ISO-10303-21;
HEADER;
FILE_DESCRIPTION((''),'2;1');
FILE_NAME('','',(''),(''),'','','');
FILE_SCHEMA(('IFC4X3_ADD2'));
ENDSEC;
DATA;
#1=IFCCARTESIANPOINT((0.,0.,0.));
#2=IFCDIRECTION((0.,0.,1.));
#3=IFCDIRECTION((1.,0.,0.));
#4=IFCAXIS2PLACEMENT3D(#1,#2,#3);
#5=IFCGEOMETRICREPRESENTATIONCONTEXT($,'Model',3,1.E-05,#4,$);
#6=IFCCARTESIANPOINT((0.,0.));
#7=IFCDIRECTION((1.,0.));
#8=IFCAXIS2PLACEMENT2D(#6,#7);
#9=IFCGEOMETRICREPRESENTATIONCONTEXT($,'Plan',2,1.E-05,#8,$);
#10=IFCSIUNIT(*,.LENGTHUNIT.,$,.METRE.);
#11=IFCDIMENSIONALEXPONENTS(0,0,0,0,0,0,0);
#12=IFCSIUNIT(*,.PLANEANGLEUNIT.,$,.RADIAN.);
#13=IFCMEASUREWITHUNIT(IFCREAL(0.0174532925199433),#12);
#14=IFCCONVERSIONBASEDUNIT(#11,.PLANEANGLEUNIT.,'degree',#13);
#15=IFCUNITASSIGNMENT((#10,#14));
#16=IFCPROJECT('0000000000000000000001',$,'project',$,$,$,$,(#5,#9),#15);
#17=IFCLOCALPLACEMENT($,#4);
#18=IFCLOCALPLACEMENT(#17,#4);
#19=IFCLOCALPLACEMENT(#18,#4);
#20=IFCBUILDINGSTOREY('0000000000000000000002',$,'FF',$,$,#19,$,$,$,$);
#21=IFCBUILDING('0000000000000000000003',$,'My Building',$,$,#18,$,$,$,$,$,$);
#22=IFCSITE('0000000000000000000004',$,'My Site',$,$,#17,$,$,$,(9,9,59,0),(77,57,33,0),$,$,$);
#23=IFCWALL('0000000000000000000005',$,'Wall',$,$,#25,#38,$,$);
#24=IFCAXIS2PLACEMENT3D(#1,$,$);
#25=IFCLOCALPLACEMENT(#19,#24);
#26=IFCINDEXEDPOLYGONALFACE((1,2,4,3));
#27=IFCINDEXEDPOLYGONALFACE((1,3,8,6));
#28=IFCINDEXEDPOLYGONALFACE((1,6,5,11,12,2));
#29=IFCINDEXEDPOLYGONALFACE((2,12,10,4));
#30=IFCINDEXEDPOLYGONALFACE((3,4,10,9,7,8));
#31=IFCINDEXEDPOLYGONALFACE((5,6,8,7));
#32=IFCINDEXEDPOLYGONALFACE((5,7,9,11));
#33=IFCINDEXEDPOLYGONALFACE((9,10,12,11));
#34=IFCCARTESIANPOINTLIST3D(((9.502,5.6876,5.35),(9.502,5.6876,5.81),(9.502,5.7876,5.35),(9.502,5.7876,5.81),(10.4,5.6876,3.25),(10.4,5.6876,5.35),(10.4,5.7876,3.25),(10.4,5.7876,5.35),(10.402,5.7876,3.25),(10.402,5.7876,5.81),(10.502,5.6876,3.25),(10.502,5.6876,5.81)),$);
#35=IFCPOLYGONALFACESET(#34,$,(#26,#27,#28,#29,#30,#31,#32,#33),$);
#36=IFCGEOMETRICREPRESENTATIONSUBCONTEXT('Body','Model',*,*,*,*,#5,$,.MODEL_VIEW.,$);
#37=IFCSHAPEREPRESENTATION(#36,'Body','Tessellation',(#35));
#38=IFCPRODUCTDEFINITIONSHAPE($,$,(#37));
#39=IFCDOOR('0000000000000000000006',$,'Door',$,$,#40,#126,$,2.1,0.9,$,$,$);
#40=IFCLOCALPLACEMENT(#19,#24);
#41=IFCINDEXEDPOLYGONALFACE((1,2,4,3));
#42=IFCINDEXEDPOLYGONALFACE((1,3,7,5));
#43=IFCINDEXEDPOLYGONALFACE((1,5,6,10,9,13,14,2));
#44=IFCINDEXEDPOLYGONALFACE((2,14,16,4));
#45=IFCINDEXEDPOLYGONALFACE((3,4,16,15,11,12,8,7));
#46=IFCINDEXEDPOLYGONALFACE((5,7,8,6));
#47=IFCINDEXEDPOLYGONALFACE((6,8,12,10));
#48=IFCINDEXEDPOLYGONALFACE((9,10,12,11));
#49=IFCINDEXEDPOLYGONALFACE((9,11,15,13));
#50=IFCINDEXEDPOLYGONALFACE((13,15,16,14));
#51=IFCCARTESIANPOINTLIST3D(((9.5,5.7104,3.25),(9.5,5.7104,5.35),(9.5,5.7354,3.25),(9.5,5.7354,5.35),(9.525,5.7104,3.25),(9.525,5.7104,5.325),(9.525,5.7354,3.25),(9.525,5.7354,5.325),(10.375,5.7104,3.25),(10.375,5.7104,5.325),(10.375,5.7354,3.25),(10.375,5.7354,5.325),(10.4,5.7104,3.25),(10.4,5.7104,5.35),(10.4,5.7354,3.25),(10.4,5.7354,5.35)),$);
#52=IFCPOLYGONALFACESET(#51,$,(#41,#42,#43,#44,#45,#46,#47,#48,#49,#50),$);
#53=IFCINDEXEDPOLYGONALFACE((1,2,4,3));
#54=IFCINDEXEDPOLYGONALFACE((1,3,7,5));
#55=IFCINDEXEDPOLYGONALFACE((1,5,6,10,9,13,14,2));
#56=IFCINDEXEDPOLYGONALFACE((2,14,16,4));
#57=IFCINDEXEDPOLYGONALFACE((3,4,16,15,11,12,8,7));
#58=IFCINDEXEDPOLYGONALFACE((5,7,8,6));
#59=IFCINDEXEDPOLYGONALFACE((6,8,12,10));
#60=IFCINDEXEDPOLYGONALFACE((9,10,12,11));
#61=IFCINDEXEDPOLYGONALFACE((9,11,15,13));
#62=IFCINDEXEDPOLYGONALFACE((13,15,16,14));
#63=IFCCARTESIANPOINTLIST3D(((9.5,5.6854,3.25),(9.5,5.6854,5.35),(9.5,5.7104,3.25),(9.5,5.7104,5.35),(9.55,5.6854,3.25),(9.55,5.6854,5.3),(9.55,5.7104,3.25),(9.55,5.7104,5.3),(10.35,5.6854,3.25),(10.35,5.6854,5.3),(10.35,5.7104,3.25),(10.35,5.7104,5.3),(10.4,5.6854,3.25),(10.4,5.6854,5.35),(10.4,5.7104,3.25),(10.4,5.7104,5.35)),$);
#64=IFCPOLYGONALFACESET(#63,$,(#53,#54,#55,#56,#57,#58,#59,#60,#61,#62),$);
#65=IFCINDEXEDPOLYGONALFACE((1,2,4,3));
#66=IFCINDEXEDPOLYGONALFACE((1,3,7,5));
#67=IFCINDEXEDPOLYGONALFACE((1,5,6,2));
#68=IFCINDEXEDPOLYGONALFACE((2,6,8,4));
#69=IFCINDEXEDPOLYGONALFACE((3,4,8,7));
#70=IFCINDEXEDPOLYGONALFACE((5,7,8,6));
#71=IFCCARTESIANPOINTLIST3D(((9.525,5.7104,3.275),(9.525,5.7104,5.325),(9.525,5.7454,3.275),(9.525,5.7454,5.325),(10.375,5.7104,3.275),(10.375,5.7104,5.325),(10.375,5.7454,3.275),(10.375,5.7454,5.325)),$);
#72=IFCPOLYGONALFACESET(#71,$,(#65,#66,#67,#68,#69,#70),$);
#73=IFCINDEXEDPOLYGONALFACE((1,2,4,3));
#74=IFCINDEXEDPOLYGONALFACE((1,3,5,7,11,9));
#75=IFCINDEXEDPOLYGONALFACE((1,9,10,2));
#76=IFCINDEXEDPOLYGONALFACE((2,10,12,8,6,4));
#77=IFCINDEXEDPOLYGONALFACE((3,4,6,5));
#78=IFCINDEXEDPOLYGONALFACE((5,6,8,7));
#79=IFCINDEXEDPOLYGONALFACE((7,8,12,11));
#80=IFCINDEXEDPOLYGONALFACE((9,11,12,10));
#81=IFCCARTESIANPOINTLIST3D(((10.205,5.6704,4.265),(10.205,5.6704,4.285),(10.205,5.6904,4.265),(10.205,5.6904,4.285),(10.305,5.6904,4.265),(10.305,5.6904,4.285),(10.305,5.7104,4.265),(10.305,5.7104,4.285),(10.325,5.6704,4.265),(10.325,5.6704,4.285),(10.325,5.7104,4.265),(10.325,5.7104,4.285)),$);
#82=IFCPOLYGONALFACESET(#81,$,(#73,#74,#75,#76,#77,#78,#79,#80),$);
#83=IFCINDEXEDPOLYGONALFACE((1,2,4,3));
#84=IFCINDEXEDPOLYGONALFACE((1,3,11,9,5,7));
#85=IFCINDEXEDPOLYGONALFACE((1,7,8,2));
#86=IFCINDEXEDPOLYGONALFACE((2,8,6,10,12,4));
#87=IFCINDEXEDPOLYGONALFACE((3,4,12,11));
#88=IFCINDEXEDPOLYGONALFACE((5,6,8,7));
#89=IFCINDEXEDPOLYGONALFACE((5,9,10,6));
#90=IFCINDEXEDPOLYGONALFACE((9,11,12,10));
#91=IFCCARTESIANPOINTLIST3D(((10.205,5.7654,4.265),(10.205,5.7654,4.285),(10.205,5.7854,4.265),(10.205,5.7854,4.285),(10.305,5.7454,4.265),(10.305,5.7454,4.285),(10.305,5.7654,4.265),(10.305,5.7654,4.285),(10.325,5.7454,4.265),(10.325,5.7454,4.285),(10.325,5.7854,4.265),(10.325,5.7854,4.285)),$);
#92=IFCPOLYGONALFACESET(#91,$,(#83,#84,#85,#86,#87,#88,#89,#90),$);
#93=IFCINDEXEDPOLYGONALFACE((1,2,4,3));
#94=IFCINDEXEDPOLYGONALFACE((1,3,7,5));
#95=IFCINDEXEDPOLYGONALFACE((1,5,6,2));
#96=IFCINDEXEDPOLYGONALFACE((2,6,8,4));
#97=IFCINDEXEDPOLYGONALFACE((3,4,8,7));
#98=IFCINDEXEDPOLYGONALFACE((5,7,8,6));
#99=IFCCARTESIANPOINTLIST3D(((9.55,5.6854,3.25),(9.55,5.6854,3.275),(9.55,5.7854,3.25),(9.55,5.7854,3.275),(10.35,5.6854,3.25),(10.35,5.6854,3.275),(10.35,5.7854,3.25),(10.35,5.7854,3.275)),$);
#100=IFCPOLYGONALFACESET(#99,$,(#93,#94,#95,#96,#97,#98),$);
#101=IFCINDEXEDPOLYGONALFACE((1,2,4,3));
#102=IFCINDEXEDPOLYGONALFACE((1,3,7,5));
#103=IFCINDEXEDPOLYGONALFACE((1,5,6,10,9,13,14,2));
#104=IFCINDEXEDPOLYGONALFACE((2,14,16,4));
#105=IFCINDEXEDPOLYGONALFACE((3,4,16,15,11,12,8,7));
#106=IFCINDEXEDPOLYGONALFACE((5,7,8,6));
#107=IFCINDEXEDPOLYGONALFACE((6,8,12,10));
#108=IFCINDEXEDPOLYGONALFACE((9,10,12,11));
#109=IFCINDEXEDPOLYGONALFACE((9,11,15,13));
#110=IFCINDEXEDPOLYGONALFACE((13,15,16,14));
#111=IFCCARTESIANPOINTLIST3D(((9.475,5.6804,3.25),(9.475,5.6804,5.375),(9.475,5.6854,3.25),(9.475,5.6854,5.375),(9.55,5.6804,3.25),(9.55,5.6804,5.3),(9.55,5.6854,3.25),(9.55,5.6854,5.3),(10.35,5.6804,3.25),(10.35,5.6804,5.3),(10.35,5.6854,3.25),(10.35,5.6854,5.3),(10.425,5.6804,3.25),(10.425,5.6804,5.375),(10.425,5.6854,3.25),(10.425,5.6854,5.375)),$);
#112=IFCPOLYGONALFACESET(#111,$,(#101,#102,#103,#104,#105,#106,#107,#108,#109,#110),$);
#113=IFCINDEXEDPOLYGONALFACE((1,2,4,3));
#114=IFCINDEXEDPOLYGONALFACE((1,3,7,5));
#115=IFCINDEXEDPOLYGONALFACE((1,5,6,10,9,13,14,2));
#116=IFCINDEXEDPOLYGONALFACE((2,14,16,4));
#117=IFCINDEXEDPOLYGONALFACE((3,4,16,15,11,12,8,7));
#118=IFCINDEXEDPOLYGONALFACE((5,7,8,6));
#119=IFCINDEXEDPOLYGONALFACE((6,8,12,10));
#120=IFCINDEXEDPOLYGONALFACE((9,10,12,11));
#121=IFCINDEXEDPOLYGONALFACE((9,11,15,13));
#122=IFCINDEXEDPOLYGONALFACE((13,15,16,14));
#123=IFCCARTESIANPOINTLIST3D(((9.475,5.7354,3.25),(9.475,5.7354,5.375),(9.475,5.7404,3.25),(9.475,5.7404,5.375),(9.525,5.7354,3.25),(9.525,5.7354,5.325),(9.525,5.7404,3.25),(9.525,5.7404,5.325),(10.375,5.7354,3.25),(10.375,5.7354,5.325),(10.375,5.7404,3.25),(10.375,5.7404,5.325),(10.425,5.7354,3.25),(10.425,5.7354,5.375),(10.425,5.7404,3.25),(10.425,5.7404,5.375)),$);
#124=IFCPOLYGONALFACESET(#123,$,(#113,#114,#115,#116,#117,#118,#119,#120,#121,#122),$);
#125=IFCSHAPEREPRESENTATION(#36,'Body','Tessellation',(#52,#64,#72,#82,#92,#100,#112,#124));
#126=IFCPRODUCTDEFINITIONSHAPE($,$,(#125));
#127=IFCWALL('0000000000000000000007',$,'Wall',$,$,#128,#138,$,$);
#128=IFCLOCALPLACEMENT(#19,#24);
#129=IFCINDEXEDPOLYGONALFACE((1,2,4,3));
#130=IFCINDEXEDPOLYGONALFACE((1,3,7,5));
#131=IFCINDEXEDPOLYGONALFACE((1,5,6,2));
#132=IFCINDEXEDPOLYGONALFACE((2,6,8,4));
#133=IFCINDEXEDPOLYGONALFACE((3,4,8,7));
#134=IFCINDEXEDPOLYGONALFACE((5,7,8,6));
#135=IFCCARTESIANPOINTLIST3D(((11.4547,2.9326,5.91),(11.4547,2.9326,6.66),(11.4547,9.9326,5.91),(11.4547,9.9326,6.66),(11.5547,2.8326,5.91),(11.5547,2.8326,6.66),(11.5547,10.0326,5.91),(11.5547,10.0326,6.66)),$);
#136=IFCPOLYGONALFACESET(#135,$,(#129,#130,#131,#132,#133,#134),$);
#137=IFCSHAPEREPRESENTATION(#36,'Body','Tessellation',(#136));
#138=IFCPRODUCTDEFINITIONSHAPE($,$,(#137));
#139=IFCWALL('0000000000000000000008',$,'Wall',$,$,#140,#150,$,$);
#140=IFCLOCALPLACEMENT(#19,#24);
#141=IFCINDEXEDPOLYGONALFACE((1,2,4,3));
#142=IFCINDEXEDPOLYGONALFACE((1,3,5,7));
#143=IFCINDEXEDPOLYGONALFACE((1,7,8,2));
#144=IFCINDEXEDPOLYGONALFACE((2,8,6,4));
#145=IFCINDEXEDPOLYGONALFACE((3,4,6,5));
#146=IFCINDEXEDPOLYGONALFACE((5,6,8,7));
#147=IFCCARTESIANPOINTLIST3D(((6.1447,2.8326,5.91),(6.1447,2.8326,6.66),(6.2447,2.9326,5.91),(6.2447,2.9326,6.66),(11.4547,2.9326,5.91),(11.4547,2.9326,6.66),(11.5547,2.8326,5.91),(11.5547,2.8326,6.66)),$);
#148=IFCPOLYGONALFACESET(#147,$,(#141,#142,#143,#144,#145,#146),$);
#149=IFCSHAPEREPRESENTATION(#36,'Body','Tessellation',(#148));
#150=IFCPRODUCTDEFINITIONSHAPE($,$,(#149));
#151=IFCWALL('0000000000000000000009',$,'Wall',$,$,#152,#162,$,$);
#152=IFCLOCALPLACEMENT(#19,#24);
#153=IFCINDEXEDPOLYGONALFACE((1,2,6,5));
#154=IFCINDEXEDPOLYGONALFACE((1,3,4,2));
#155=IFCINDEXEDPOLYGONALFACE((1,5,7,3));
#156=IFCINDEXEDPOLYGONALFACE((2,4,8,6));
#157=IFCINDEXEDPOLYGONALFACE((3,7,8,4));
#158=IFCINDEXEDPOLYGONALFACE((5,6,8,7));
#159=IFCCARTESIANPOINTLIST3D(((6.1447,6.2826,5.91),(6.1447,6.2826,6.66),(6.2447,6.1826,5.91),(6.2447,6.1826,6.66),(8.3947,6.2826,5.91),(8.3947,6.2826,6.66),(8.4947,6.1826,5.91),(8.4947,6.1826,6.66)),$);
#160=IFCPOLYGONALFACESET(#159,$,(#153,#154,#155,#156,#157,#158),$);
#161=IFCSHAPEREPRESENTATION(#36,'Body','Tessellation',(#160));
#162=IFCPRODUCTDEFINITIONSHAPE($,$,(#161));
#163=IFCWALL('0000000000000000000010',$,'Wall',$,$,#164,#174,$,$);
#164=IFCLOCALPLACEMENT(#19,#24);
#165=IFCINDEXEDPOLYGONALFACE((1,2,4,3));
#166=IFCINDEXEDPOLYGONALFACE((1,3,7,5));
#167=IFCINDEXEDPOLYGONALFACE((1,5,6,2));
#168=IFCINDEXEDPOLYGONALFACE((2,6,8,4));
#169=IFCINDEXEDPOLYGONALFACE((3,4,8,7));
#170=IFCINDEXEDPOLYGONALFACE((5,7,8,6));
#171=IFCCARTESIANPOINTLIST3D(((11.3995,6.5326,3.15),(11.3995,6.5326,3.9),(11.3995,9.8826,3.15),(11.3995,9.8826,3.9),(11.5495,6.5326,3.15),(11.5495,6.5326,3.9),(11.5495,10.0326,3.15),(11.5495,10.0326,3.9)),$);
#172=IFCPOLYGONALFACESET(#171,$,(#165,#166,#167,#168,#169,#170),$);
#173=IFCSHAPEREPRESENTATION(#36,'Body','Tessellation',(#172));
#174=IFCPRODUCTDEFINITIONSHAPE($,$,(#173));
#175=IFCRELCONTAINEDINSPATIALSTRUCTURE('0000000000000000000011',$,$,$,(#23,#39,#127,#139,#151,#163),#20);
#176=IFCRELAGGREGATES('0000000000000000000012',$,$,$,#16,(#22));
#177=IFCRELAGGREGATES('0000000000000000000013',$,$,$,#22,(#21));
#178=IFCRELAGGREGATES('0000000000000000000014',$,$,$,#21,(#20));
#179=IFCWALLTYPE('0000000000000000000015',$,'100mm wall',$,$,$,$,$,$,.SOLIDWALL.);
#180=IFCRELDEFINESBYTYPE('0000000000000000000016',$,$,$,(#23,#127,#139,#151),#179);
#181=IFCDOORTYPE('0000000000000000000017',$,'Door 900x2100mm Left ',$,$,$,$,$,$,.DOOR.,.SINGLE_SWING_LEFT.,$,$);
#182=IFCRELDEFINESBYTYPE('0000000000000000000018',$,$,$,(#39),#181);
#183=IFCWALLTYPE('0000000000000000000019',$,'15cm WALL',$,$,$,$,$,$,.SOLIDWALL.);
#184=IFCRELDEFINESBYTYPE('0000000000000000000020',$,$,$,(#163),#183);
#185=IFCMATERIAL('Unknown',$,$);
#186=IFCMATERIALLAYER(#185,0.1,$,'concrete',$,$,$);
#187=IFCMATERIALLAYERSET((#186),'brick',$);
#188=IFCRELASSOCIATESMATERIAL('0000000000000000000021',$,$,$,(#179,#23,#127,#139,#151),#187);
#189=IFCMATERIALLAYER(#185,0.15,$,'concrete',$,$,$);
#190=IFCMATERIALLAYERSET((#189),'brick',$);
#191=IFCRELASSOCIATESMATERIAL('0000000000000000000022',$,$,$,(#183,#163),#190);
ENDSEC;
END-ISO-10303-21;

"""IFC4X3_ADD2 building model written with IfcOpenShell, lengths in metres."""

from ifc_helpers import new_model, entity, si_unit, converted_unit, frame, origin_with_axes, origin_2d_with_axis, place, context, subcontext, project, spatial, line, indexed_curve, outline, extrude, shape, source, transform, mapped, material, layer, layer_set, layer_usage, type_object, type_shapes, element, fill, save


model = new_model("IFC4X3_ADD2")

# Units and contexts
model_context = context("Model", 3, precision=1e-05, world=origin_with_axes())
plan_context = context("Plan", 2, precision=1e-05, world=origin_2d_with_axis())
body_context_1 = subcontext(model_context, "Body", "Model", "MODEL_VIEW")
body_context_2 = subcontext(plan_context, "Body", "Plan", "PLAN_VIEW")
ifc_project = project(units=[si_unit("LENGTHUNIT", "METRE"), converted_unit("PLANEANGLEUNIT", "degree", entity("IfcReal", 0.0174532925199433), si_unit("PLANEANGLEUNIT", "RADIAN"), dimensions=[0, 0, 0, 0, 0, 0, 0])], contexts=[model_context, plan_context])

# Site, building, storey
site_placement = place(None, origin_with_axes())
site = spatial("IfcSite", under=ifc_project, at=site_placement, Name="My Site", RefLatitude=(9, 9, 59, 0), RefLongitude=(77, 57, 33, 0))
building_placement = place(site_placement, origin_with_axes())
building = spatial("IfcBuilding", under=site, at=building_placement, Name="My Building")
storey_placement = place(building_placement, origin_with_axes())
storey = spatial("IfcBuildingStorey", under=building, at=storey_placement, Name="FF")

# Shared definitions
ifc_material = material(Name="Unknown")

# Shared definitions
ifc_layer_1 = layer(ifc_material, 0.1, Name="concrete")
ifc_layer_set_1 = layer_set([ifc_layer_1], Name="brick")
wall_type_1 = type_object("IfcWallType", Name="100mm wall", PredefinedType="SOLIDWALL", material=ifc_layer_set_1)
shared_shape_1 = source(origin_with_axes(), body_context_1, "Body", "SweptSolid", [
    extrude(outline(indexed_curve([(0.0, 0.0), (0.9, 0.0), (0.9, 2.1), (0.0, 2.1)], segments=[line(1, 2, 3, 4, 1)])), frame((0.0, -0.6, 0.0), z_axis=(0.0, -1.0, 0.0), x_axis=(1.0, 0.0, 0.0)), (0.0, 0.0, -1.0), 1.2),
])
door_type_1 = type_object("IfcDoorType", Name="Door 900x2100mm Left ", OperationType="SINGLE_SWING_LEFT", PredefinedType="DOOR")
shared_shape_2 = source(origin_with_axes(), body_context_1, "Body", "SweptSolid", [
    extrude(outline(indexed_curve([(0.0, 0.0), (0.0, 2.1), (0.9, 2.1), (0.9, 0.0), (0.875, 0.0), (0.875, 2.075), (0.025, 2.075), (0.025, 0.0)], segments=[line(1, 2, 3, 4, 5, 6, 7, 8, 1)])), frame((0.0, 0.025, 0.0), z_axis=(0.0, -1.0, 0.0), x_axis=(1.0, 0.0, 0.0)), (0.0, 0.0, -1.0), 0.025),
    extrude(outline(indexed_curve([(0.0, 0.0), (0.0, 2.1), (0.9, 2.1), (0.9, 0.0), (0.85, 0.0), (0.85, 2.05), (0.05, 2.05), (0.05, 0.0)], segments=[line(1, 2, 3, 4, 5, 6, 7, 8, 1)])), frame((0.0, 0.0, 0.0), z_axis=(0.0, -1.0, 0.0), x_axis=(1.0, 0.0, 0.0)), (0.0, 0.0, -1.0), 0.025),
    extrude(outline(indexed_curve([(0.0, 0.0), (0.85, 0.0), (0.85, 0.035), (0.0, 0.035)], segments=[line(1, 2, 3, 4, 1)])), frame((0.025, 0.025, 0.025), z_axis=(0.0, 0.0, 1.0), x_axis=(1.0, 0.0, 0.0)), (0.0, 0.0, 1.0), 2.05),
    extrude(outline(indexed_curve([(0.0, 0.0), (0.0, -0.04), (-0.12, -0.04), (-0.12, -0.02), (-0.02, -0.02), (-0.02, 0.0)], segments=[line(1, 2, 3, 4, 5, 6, 1)])), frame((0.825, 0.025, 1.015), z_axis=(0.0, 0.0, 1.0), x_axis=(1.0, 0.0, 0.0)), (0.0, 0.0, 1.0), 0.02),
    extrude(outline(indexed_curve([(0.0, 0.0), (0.0, 0.04), (-0.12, 0.04), (-0.12, 0.02), (-0.02, 0.02), (-0.02, 0.0)], segments=[line(1, 2, 3, 4, 5, 6, 1)])), frame((0.825, 0.06, 1.015), z_axis=(0.0, 0.0, 1.0), x_axis=(1.0, 0.0, 0.0)), (0.0, 0.0, 1.0), 0.02),
    extrude(outline(indexed_curve([(0.0, 0.0), (0.8, 0.0), (0.8, 0.1), (0.0, 0.1)], segments=[line(1, 2, 3, 4, 1)])), frame((0.05, 0.0, 0.0), z_axis=(0.0, 0.0, 1.0), x_axis=(1.0, 0.0, 0.0)), (0.0, 0.0, 1.0), 0.025),
    extrude(outline(indexed_curve([(0.0, 0.0), (0.0, 2.125), (0.95, 2.125), (0.95, 0.0), (0.875, 0.0), (0.875, 2.05), (0.075, 2.05), (0.075, 0.0)], segments=[line(1, 2, 3, 4, 5, 6, 7, 8, 1)])), frame((-0.025, -0.005, 0.0), z_axis=(0.0, -1.0, 0.0), x_axis=(1.0, 0.0, 0.0)), (0.0, 0.0, -1.0), 0.005),
    extrude(outline(indexed_curve([(0.0, 0.0), (0.0, 2.125), (0.95, 2.125), (0.95, 0.0), (0.9, 0.0), (0.9, 2.075), (0.05, 2.075), (0.05, 0.0)], segments=[line(1, 2, 3, 4, 5, 6, 7, 8, 1)])), frame((-0.025, 0.05, 0.0), z_axis=(0.0, -1.0, 0.0), x_axis=(1.0, 0.0, 0.0)), (0.0, 0.0, -1.0), 0.005),
])
shared_shape_3 = source(origin_with_axes(), body_context_2, "Body", "Curve2D", [
    entity("IfcIndexedPolyCurve", entity("IfcCartesianPointList2D", [[0.0, 0.0], [0.0, 0.05], [0.025, 0.05], [0.025, 0.025], [0.05, 0.025], [0.05, 0.0]]), [entity("IfcLineIndex", [1, 2, 3, 4, 5, 6, 1])]),
    entity("IfcIndexedPolyCurve", entity("IfcCartesianPointList2D", [[0.9, 0.0], [0.9, 0.05], [0.875, 0.05], [0.875, 0.025], [0.85, 0.025], [0.85, 0.0]]), [entity("IfcLineIndex", [1, 2, 3, 4, 5, 6, 1])]),
    entity("IfcTrimmedCurve", entity("IfcEllipse", entity("IfcAxis2Placement2D", entity("IfcCartesianPoint", [0.06, 0.05]), entity("IfcDirection", [1.0, 0.0])), 0.815, 0.85), [entity("IfcCartesianPoint", [0.875, 0.05])], [entity("IfcCartesianPoint", [0.06, 0.9])], True, "CARTESIAN"),
    entity("IfcIndexedPolyCurve", entity("IfcCartesianPointList2D", [[0.025, 0.05], [0.06, 0.05], [0.06, 0.9], [0.025, 0.9]]), [entity("IfcLineIndex", [1, 2, 3, 4, 1])]),
])
type_shapes(door_type_1, [shared_shape_2, shared_shape_3])

# Wall, opening, door
ifc_layer_usage_1 = layer_usage(ifc_layer_set_1, "AXIS2", "POSITIVE", 0.0)
wall_1_placement = place(storey_placement, frame((10.502, 5.7876, 3.25), z_axis=(0.0, 0.0, 1.0), x_axis=(-1.0, 0.0, 0.0)))
wall_1 = element("IfcWall", 1, at=wall_1_placement, inside=storey, type_object=wall_type_1, material=ifc_layer_usage_1, Name="Wall", context=body_context_1, shape_type="SweptSolid", body=[
    extrude(outline(indexed_curve([(0.1, 0.0), (0.0, 0.1), (1.0, 0.1), (1.0, 0.0)], segments=[line(1, 2, 3, 4, 1)])), origin_with_axes(), (0.0, 0.0, 1.0), 2.56),
])
opening_1_placement = place(wall_1_placement, frame((1.002, 0.1022, 0.0), z_axis=(0.0, 0.0, 1.0), x_axis=(-1.0, 0.0, 0.0)))
opening_1 = element("IfcOpeningElement", 2, at=opening_1_placement, cuts=wall_1, PredefinedType="OPENING", context=body_context_1, shape_type="MappedRepresentation", body=[
    mapped(shared_shape_1, transform((0.0, 0.0, 0.0), x_axis=(1.0, 0.0, 0.0), y_axis=(0.0, 1.0, 0.0), z_axis=(0.0, 0.0, 1.0), scale=1.0)),
])
door_1_placement = place(opening_1_placement, frame((0.0, 0.0, 0.0), z_axis=(0.0, 0.0, 1.0), x_axis=(1.0, 0.0, 0.0)))
door_1 = element("IfcDoor", 3, at=door_1_placement, inside=storey, type_object=door_type_1, Name="Door", OverallHeight=2.1, OverallWidth=0.9, shapes=[
    shape(body_context_1, "Body", "MappedRepresentation", [mapped(shared_shape_2, transform((0.0, 0.0, 0.0), x_axis=(1.0, 0.0, 0.0), y_axis=(0.0, 1.0, 0.0), z_axis=(0.0, 0.0, 1.0), scale=1.0))]),
    shape(body_context_2, "Body", "MappedRepresentation", [mapped(shared_shape_3, transform((0.0, 0.0, 0.0), x_axis=(1.0, 0.0, 0.0), y_axis=(0.0, 1.0, 0.0), z_axis=(0.0, 0.0, 1.0), scale=1.0))]),
])
fill(opening_1, door_1)

# Walls
ifc_layer_usage_2 = layer_usage(ifc_layer_set_1, "AXIS2", "POSITIVE", 0.0)
wall_2_placement = place(storey_placement, frame((11.5547, 2.9326, 5.91), z_axis=(0.0, 0.0, 1.0), x_axis=(0.0, 1.0, 0.0)))
element("IfcWall", 4, at=wall_2_placement, inside=storey, type_object=wall_type_1, material=ifc_layer_usage_2, Name="Wall", context=body_context_1, shape_type="SweptSolid", body=[
    extrude(outline(indexed_curve([(-0.1, 0.0), (0.0, 0.1), (7.0, 0.1), (7.1, 0.0)], segments=[line(1, 2, 3, 4, 1)])), origin_with_axes(), (0.0, 0.0, 1.0), 0.75),
])
ifc_layer_usage_3 = layer_usage(ifc_layer_set_1, "AXIS2", "POSITIVE", 0.0)
wall_3_placement = place(storey_placement, frame((11.5547, 2.9326, 5.91), z_axis=(0.0, 0.0, 1.0), x_axis=(-1.0, 0.0, 0.0)))
element("IfcWall", 5, at=wall_3_placement, inside=storey, type_object=wall_type_1, material=ifc_layer_usage_3, Name="Wall", context=body_context_1, shape_type="SweptSolid", body=[
    extrude(outline(indexed_curve([(0.1, 0.0), (0.0, 0.1), (5.41, 0.1), (5.31, 0.0)], segments=[line(1, 2, 3, 4, 1)])), origin_with_axes(), (0.0, 0.0, 1.0), 0.75),
])
ifc_layer_usage_4 = layer_usage(ifc_layer_set_1, "AXIS2", "POSITIVE", 0.0)
wall_4_placement = place(storey_placement, frame((8.3947, 6.2826, 5.91), z_axis=(0.0, 0.0, 1.0), x_axis=(-1.0, 0.0, 0.0)))
element("IfcWall", 6, at=wall_4_placement, inside=storey, type_object=wall_type_1, material=ifc_layer_usage_4, Name="Wall", context=body_context_1, shape_type="SweptSolid", body=[
    extrude(outline(indexed_curve([(0.0, 0.0), (-0.1, 0.1), (2.15, 0.1), (2.25, 0.0)], segments=[line(1, 2, 3, 4, 1)])), origin_with_axes(), (0.0, 0.0, 1.0), 0.75),
])
ifc_layer_2 = layer(ifc_material, 0.15, Name="concrete")
ifc_layer_set_2 = layer_set([ifc_layer_2], Name="brick")
ifc_layer_usage_5 = layer_usage(ifc_layer_set_2, "AXIS2", "POSITIVE", 0.0)
wall_type_2 = type_object("IfcWallType", Name="15cm WALL", PredefinedType="SOLIDWALL", material=ifc_layer_set_2)
wall_5_placement = place(storey_placement, frame((11.5495, 6.5326, 3.15), z_axis=(0.0, 0.0, 1.0), x_axis=(0.0, 1.0, 0.0)))
element("IfcWall", 7, at=wall_5_placement, inside=storey, type_object=wall_type_2, material=ifc_layer_usage_5, Name="Wall", context=body_context_1, shape_type="SweptSolid", body=[
    extrude(outline(indexed_curve([(0.0, 0.0), (0.0, 0.15), (3.35, 0.15), (3.5, 0.0)], segments=[line(1, 2, 3, 4, 1)])), origin_with_axes(), (0.0, 0.0, 1.0), 0.75),
])

save(model, "model.ifc")
